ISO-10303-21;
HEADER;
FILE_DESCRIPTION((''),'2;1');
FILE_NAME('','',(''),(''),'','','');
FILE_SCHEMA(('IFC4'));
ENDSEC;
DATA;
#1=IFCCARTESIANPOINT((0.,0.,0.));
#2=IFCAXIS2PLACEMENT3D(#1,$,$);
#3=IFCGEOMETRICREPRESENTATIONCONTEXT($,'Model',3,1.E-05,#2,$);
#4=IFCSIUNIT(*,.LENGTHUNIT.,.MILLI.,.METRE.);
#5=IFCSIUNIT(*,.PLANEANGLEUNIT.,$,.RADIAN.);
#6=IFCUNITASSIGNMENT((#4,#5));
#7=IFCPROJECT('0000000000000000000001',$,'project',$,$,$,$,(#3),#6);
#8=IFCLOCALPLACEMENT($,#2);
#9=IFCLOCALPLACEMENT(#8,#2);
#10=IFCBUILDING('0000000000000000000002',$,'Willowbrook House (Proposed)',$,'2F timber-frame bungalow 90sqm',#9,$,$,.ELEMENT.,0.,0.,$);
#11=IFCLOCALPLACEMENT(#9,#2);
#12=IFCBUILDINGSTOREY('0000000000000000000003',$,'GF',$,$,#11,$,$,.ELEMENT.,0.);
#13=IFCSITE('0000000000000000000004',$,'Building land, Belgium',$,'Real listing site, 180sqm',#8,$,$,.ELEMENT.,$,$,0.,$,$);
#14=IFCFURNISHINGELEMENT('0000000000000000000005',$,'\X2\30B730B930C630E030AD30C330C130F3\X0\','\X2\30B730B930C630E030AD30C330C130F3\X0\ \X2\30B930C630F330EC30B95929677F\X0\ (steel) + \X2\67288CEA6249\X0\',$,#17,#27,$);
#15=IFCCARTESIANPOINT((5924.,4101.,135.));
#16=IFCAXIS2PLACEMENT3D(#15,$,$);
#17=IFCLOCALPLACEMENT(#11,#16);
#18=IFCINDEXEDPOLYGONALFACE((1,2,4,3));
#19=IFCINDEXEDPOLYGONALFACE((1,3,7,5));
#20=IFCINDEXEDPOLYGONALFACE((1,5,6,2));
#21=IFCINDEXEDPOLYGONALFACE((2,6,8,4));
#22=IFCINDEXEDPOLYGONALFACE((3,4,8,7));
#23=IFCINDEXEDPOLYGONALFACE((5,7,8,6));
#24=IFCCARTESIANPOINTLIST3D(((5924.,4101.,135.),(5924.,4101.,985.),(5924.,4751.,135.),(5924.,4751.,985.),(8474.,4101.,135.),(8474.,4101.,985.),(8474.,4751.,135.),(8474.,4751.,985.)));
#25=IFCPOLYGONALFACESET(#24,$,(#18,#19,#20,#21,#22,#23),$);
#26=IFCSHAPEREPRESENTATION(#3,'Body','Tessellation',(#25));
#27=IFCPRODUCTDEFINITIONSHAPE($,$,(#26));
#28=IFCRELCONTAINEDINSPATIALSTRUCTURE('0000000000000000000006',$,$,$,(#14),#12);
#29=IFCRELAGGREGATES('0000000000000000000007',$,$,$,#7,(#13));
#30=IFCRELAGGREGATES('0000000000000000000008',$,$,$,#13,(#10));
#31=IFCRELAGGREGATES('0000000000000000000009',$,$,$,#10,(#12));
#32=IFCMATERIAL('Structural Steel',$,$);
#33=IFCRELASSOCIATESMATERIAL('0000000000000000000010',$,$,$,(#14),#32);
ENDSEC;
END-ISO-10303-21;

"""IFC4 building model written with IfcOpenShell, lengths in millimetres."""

from ifc_helpers import new_model, si_unit, frame, frame_2d, origin, place, context, project, spatial, rectangle, extrude, material, element, save


model = new_model("IFC4")

# Units and contexts
model_context = context("Model", 3, precision=1e-05, world=origin())
ifc_project = project(units=[si_unit("LENGTHUNIT", "METRE", prefix="MILLI"), si_unit("PLANEANGLEUNIT", "RADIAN")], contexts=[model_context])

# Site, building, storey
site_placement = place(None, origin())
site = spatial("IfcSite", under=ifc_project, at=site_placement, Name="Building land, Belgium", ObjectType="Real listing site, 180sqm", CompositionType="ELEMENT", RefElevation=0.0)
building_placement = place(site_placement, origin())
building = spatial("IfcBuilding", under=site, at=building_placement, Name="Willowbrook House (Proposed)", ObjectType="2F timber-frame bungalow 90sqm", CompositionType="ELEMENT", ElevationOfRefHeight=0.0, ElevationOfTerrain=0.0)
storey_placement = place(building_placement, origin())
storey = spatial("IfcBuildingStorey", under=building, at=storey_placement, Name="GF", CompositionType="ELEMENT", Elevation=0.0)

# Furnishing element
ifc_material_1 = material(Name="Structural Steel")
furnishing_placement = place(storey_placement, frame((5924.0, 4101.0, 135.0)))
element("IfcFurnishingElement", 1, at=furnishing_placement, inside=storey, material=ifc_material_1, Name="システムキッチン", Description="システムキッチン ステンレス天板 (steel) + 木質扉", context=model_context, shape_type="SweptSolid", body=[
    extrude(rectangle(XDim=2550.0, YDim=650.0, at=frame_2d((1275.0, 325.0))), frame((5924.0, 4101.0, 135.0)), (0.0, 0.0, 1.0), 850.0),
])

save(model, "model.ifc")
